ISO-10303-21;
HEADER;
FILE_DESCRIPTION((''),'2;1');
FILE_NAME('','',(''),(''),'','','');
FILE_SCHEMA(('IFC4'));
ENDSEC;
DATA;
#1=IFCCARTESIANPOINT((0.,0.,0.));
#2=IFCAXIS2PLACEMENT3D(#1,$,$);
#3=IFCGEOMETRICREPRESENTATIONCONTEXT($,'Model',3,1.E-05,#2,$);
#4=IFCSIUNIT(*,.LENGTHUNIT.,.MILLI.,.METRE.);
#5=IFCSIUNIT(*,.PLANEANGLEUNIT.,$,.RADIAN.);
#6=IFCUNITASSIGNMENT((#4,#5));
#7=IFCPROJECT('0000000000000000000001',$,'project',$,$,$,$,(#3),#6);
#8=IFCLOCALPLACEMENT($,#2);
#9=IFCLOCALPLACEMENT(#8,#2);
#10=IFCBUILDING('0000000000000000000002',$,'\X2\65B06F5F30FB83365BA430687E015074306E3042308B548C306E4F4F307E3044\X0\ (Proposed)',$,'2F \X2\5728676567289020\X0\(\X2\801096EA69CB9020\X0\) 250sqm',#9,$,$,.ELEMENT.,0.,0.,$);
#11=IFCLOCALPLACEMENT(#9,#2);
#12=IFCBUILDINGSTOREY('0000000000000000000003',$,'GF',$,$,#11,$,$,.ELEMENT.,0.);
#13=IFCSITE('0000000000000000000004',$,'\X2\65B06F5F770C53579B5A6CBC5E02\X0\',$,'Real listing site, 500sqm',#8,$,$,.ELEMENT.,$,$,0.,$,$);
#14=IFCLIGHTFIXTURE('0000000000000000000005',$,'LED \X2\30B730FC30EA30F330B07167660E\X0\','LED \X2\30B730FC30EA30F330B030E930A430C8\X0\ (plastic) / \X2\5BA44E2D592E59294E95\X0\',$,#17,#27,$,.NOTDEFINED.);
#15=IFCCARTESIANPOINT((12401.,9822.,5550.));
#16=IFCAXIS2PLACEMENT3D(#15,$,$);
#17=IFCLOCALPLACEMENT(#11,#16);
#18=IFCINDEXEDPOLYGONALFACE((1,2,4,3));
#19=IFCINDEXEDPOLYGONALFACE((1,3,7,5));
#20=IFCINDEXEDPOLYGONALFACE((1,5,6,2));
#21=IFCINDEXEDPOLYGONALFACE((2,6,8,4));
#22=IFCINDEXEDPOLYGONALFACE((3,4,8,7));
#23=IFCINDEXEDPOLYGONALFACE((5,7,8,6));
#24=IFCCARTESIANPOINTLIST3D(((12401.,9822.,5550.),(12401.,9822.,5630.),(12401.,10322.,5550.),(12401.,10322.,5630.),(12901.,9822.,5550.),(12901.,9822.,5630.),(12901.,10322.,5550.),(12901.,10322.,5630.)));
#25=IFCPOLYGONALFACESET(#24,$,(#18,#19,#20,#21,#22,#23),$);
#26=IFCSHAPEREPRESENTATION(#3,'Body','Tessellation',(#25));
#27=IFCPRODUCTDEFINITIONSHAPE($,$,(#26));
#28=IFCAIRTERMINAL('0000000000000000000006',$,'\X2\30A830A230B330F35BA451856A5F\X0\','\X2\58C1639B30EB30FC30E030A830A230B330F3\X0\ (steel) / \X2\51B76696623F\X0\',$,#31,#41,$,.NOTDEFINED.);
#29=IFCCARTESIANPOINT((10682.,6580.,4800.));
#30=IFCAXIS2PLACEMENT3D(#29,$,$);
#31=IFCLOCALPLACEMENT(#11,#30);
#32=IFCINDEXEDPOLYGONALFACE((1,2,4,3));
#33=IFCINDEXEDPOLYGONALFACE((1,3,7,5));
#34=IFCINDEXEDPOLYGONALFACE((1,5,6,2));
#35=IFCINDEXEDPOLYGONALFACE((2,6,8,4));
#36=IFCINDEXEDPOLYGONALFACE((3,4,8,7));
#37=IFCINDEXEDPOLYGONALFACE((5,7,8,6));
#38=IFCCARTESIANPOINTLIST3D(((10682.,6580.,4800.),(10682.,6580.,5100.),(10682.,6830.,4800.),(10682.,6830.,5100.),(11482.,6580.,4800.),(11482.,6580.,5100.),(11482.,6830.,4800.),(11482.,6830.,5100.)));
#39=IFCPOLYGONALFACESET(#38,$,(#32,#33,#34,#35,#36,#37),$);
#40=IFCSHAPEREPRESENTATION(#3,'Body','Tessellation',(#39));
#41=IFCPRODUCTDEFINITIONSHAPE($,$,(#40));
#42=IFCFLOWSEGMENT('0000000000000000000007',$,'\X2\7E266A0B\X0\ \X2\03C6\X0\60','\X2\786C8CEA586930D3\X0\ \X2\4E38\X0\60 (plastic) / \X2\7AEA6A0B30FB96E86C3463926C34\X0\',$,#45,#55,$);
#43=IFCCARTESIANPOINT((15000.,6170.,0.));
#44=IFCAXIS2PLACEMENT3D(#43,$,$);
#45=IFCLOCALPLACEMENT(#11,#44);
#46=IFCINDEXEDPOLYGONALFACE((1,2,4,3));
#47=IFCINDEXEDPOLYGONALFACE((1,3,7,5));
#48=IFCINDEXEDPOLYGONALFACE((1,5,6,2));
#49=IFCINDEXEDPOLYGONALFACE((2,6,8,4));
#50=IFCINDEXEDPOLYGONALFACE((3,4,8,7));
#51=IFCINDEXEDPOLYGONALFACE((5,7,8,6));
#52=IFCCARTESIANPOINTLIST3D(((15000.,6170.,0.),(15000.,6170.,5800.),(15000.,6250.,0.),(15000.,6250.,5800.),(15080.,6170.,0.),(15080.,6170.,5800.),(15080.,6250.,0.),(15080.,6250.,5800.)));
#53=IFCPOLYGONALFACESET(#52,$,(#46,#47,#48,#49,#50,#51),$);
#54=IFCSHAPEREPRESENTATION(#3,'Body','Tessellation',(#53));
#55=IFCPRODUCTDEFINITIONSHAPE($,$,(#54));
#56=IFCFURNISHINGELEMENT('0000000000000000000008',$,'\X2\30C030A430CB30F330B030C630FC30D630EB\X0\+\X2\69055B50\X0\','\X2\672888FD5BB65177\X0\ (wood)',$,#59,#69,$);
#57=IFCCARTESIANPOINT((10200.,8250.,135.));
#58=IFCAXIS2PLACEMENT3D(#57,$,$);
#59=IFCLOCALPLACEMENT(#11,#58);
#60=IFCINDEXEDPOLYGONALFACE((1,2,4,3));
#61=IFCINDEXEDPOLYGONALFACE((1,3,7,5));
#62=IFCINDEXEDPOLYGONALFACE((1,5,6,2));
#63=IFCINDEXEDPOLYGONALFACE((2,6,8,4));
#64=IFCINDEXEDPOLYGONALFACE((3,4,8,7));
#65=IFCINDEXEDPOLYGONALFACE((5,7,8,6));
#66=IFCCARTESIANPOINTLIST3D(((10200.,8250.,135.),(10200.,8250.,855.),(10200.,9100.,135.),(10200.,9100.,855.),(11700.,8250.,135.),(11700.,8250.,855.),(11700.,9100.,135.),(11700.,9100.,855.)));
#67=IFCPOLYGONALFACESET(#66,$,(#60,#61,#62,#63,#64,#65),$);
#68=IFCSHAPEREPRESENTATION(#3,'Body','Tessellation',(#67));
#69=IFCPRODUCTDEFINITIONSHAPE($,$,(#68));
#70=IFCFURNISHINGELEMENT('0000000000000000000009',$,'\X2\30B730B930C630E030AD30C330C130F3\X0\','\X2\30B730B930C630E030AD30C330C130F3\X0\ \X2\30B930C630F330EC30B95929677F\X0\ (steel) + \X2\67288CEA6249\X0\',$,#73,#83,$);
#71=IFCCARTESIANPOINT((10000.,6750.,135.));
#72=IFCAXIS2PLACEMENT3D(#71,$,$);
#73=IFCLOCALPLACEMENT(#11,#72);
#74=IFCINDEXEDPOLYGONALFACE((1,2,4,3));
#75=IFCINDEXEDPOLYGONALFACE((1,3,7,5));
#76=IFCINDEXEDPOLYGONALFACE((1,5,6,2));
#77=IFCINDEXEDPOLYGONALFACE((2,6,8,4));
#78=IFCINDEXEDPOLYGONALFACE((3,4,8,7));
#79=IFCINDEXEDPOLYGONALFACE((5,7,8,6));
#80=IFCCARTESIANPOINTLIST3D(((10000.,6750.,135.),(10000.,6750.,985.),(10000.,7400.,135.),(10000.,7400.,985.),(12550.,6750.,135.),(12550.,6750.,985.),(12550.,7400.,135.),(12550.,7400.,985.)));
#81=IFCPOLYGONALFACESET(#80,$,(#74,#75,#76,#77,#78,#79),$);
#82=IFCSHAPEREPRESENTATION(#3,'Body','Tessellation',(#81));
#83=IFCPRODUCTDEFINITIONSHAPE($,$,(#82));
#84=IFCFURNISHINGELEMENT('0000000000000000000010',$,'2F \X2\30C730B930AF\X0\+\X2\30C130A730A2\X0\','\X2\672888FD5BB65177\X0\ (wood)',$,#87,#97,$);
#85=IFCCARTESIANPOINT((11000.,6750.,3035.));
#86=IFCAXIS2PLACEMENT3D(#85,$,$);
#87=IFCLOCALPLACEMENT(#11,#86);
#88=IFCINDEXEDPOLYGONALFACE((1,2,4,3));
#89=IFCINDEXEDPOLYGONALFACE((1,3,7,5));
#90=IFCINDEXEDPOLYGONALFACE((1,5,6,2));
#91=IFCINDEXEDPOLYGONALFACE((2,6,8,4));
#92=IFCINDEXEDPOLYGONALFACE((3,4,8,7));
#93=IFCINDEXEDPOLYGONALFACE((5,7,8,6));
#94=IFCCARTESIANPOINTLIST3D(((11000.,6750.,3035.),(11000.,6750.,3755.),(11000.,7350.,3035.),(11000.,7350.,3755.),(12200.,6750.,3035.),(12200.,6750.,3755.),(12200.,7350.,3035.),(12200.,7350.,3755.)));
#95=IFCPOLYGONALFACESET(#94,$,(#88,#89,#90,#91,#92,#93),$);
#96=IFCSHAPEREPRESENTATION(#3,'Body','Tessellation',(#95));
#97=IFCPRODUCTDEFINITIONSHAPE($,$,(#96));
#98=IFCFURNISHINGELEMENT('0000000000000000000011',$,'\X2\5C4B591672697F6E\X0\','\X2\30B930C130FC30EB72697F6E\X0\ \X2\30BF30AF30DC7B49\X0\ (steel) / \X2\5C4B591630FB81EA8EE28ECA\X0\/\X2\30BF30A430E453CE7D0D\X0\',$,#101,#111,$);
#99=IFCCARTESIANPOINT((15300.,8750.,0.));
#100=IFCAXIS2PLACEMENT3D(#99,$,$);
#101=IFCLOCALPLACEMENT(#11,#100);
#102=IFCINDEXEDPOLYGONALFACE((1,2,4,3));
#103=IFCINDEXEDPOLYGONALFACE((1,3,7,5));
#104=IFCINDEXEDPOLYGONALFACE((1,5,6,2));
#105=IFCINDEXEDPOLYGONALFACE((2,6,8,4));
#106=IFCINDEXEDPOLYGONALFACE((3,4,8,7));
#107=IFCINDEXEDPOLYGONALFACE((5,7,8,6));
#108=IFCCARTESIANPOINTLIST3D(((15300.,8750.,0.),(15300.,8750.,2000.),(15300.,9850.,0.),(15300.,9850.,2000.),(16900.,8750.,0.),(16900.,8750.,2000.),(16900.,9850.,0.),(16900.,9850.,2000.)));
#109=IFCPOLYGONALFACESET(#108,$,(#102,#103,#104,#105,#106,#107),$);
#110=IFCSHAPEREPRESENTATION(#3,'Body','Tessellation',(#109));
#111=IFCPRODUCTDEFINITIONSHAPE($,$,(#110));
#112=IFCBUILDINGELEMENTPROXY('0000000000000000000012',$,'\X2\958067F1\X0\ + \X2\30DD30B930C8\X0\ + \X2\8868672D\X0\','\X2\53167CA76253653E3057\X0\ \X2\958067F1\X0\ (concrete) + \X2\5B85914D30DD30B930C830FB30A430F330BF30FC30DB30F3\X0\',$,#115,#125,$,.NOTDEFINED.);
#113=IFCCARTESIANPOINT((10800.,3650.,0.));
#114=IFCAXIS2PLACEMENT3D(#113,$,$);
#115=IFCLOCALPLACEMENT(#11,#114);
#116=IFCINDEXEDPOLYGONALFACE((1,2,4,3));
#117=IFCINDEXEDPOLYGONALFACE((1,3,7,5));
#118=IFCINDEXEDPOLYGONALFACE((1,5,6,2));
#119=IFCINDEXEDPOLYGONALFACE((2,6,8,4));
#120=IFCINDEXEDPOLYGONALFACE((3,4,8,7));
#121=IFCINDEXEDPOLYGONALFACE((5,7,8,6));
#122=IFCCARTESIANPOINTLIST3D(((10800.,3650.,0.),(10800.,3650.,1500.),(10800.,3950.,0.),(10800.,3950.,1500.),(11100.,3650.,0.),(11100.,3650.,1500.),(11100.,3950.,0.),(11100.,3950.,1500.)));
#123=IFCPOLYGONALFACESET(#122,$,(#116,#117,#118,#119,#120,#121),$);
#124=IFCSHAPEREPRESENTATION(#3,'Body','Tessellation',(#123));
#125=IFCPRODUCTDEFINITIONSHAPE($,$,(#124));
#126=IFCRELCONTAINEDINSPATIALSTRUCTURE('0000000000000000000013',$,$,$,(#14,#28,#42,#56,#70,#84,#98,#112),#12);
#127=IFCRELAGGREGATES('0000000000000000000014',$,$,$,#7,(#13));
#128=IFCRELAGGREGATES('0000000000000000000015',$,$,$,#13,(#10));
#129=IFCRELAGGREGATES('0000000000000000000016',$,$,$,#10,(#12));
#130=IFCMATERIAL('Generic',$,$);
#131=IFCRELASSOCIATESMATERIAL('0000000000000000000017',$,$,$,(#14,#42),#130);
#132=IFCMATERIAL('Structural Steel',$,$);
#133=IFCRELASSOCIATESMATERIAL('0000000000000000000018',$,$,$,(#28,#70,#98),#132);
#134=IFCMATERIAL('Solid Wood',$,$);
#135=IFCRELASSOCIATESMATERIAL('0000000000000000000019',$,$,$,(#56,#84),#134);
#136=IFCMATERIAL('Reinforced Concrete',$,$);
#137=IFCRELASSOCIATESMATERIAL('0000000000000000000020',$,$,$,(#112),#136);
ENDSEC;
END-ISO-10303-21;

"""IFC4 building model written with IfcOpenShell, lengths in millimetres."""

from ifc_helpers import new_model, si_unit, frame, frame_2d, origin, place, context, project, spatial, rectangle, extrude, material, element, save


model = new_model("IFC4")

# Units and contexts
model_context = context("Model", 3, precision=1e-05, world=origin())
ifc_project = project(units=[si_unit("LENGTHUNIT", "METRE", prefix="MILLI"), si_unit("PLANEANGLEUNIT", "RADIAN")], contexts=[model_context])

# Site, building, storey
site_placement = place(None, origin())
site = spatial("IfcSite", under=ifc_project, at=site_placement, Name="新潟県南魚沼市", ObjectType="Real listing site, 500sqm", CompositionType="ELEMENT", RefElevation=0.0)
building_placement = place(site_placement, origin())
building = spatial("IfcBuilding", under=site, at=building_placement, Name="新潟・茶室と縁側のある和の住まい (Proposed)", ObjectType="2F 在来木造(耐雪構造) 250sqm", CompositionType="ELEMENT", ElevationOfRefHeight=0.0, ElevationOfTerrain=0.0)
storey_placement = place(building_placement, origin())
storey = spatial("IfcBuildingStorey", under=building, at=storey_placement, Name="GF", CompositionType="ELEMENT", Elevation=0.0)

# Shared definitions
ifc_material_1 = material(Name="Solid Wood")

# Shared definitions
ifc_material_2 = material(Name="Reinforced Concrete")

# Shared definitions
ifc_material_3 = material(Name="Structural Steel")

# Shared definitions
ifc_material_4 = material(Name="Generic")

# Light fixture
light_fixture_placement = place(storey_placement, frame((12401.0, 9822.0, 5550.0)))
element("IfcLightFixture", 1, at=light_fixture_placement, inside=storey, material=ifc_material_4, Name="LED シーリング照明", Description="LED シーリングライト (plastic) / 室中央天井", PredefinedType="NOTDEFINED", context=model_context, shape_type="SweptSolid", body=[
    extrude(rectangle(XDim=500.0, YDim=500.0, at=frame_2d((250.0, 250.0))), frame((12401.0, 9822.0, 5550.0)), (0.0, 0.0, 1.0), 80.0),
])

# Air terminal
air_terminal_placement = place(storey_placement, frame((10682.0, 6580.0, 4800.0)))
element("IfcAirTerminal", 2, at=air_terminal_placement, inside=storey, material=ifc_material_3, Name="エアコン室内機", Description="壁掛ルームエアコン (steel) / 冷暖房", PredefinedType="NOTDEFINED", context=model_context, shape_type="SweptSolid", body=[
    extrude(rectangle(XDim=800.0, YDim=250.0, at=frame_2d((400.0, 125.0))), frame((10682.0, 6580.0, 4800.0)), (0.0, 0.0, 1.0), 300.0),
])

# Flow segment
flow_segment_placement = place(storey_placement, frame((15000.0, 6170.0, 0.0)))
element("IfcFlowSegment", 3, at=flow_segment_placement, inside=storey, material=ifc_material_4, Name="縦樋 φ60", Description="硬質塩ビ 丸60 (plastic) / 竪樋・雨水排水", context=model_context, shape_type="SweptSolid", body=[
    extrude(rectangle(XDim=80.0, YDim=80.0, at=frame_2d((40.0, 40.0))), frame((15000.0, 6170.0, 0.0)), (0.0, 0.0, 1.0), 5800.0),
])

# Furnishing elements
furnishing_1_placement = place(storey_placement, frame((10200.0, 8250.0, 135.0)))
element("IfcFurnishingElement", 4, at=furnishing_1_placement, inside=storey, material=ifc_material_1, Name="ダイニングテーブル+椅子", Description="木製家具 (wood)", context=model_context, shape_type="SweptSolid", body=[
    extrude(rectangle(XDim=1500.0, YDim=850.0, at=frame_2d((750.0, 425.0))), frame((10200.0, 8250.0, 135.0)), (0.0, 0.0, 1.0), 720.0),
])
furnishing_2_placement = place(storey_placement, frame((10000.0, 6750.0, 135.0)))
element("IfcFurnishingElement", 5, at=furnishing_2_placement, inside=storey, material=ifc_material_3, Name="システムキッチン", Description="システムキッチン ステンレス天板 (steel) + 木質扉", context=model_context, shape_type="SweptSolid", body=[
    extrude(rectangle(XDim=2550.0, YDim=650.0, at=frame_2d((1275.0, 325.0))), frame((10000.0, 6750.0, 135.0)), (0.0, 0.0, 1.0), 850.0),
])
furnishing_3_placement = place(storey_placement, frame((11000.0, 6750.0, 3035.0)))
element("IfcFurnishingElement", 6, at=furnishing_3_placement, inside=storey, material=ifc_material_1, Name="2F デスク+チェア", Description="木製家具 (wood)", context=model_context, shape_type="SweptSolid", body=[
    extrude(rectangle(XDim=1200.0, YDim=600.0, at=frame_2d((600.0, 300.0))), frame((11000.0, 6750.0, 3035.0)), (0.0, 0.0, 1.0), 720.0),
])
furnishing_4_placement = place(storey_placement, frame((15300.0, 8750.0, 0.0)))
element("IfcFurnishingElement", 7, at=furnishing_4_placement, inside=storey, material=ifc_material_3, Name="屋外物置", Description="スチール物置 タクボ等 (steel) / 屋外・自転車/タイヤ収納", context=model_context, shape_type="SweptSolid", body=[
    extrude(rectangle(XDim=1600.0, YDim=1100.0, at=frame_2d((800.0, 550.0))), frame((15300.0, 8750.0, 0.0)), (0.0, 0.0, 1.0), 2000.0),
])

# Building element proxy
proxy_placement = place(storey_placement, frame((10800.0, 3650.0, 0.0)))
element("IfcBuildingElementProxy", 8, at=proxy_placement, inside=storey, material=ifc_material_2, Name="門柱 + ポスト + 表札", Description="化粧打放し 門柱 (concrete) + 宅配ポスト・インターホン", PredefinedType="NOTDEFINED", context=model_context, shape_type="SweptSolid", body=[
    extrude(rectangle(XDim=300.0, YDim=300.0, at=frame_2d((150.0, 150.0))), frame((10800.0, 3650.0, 0.0)), (0.0, 0.0, 1.0), 1500.0),
])

save(model, "model.ifc")
